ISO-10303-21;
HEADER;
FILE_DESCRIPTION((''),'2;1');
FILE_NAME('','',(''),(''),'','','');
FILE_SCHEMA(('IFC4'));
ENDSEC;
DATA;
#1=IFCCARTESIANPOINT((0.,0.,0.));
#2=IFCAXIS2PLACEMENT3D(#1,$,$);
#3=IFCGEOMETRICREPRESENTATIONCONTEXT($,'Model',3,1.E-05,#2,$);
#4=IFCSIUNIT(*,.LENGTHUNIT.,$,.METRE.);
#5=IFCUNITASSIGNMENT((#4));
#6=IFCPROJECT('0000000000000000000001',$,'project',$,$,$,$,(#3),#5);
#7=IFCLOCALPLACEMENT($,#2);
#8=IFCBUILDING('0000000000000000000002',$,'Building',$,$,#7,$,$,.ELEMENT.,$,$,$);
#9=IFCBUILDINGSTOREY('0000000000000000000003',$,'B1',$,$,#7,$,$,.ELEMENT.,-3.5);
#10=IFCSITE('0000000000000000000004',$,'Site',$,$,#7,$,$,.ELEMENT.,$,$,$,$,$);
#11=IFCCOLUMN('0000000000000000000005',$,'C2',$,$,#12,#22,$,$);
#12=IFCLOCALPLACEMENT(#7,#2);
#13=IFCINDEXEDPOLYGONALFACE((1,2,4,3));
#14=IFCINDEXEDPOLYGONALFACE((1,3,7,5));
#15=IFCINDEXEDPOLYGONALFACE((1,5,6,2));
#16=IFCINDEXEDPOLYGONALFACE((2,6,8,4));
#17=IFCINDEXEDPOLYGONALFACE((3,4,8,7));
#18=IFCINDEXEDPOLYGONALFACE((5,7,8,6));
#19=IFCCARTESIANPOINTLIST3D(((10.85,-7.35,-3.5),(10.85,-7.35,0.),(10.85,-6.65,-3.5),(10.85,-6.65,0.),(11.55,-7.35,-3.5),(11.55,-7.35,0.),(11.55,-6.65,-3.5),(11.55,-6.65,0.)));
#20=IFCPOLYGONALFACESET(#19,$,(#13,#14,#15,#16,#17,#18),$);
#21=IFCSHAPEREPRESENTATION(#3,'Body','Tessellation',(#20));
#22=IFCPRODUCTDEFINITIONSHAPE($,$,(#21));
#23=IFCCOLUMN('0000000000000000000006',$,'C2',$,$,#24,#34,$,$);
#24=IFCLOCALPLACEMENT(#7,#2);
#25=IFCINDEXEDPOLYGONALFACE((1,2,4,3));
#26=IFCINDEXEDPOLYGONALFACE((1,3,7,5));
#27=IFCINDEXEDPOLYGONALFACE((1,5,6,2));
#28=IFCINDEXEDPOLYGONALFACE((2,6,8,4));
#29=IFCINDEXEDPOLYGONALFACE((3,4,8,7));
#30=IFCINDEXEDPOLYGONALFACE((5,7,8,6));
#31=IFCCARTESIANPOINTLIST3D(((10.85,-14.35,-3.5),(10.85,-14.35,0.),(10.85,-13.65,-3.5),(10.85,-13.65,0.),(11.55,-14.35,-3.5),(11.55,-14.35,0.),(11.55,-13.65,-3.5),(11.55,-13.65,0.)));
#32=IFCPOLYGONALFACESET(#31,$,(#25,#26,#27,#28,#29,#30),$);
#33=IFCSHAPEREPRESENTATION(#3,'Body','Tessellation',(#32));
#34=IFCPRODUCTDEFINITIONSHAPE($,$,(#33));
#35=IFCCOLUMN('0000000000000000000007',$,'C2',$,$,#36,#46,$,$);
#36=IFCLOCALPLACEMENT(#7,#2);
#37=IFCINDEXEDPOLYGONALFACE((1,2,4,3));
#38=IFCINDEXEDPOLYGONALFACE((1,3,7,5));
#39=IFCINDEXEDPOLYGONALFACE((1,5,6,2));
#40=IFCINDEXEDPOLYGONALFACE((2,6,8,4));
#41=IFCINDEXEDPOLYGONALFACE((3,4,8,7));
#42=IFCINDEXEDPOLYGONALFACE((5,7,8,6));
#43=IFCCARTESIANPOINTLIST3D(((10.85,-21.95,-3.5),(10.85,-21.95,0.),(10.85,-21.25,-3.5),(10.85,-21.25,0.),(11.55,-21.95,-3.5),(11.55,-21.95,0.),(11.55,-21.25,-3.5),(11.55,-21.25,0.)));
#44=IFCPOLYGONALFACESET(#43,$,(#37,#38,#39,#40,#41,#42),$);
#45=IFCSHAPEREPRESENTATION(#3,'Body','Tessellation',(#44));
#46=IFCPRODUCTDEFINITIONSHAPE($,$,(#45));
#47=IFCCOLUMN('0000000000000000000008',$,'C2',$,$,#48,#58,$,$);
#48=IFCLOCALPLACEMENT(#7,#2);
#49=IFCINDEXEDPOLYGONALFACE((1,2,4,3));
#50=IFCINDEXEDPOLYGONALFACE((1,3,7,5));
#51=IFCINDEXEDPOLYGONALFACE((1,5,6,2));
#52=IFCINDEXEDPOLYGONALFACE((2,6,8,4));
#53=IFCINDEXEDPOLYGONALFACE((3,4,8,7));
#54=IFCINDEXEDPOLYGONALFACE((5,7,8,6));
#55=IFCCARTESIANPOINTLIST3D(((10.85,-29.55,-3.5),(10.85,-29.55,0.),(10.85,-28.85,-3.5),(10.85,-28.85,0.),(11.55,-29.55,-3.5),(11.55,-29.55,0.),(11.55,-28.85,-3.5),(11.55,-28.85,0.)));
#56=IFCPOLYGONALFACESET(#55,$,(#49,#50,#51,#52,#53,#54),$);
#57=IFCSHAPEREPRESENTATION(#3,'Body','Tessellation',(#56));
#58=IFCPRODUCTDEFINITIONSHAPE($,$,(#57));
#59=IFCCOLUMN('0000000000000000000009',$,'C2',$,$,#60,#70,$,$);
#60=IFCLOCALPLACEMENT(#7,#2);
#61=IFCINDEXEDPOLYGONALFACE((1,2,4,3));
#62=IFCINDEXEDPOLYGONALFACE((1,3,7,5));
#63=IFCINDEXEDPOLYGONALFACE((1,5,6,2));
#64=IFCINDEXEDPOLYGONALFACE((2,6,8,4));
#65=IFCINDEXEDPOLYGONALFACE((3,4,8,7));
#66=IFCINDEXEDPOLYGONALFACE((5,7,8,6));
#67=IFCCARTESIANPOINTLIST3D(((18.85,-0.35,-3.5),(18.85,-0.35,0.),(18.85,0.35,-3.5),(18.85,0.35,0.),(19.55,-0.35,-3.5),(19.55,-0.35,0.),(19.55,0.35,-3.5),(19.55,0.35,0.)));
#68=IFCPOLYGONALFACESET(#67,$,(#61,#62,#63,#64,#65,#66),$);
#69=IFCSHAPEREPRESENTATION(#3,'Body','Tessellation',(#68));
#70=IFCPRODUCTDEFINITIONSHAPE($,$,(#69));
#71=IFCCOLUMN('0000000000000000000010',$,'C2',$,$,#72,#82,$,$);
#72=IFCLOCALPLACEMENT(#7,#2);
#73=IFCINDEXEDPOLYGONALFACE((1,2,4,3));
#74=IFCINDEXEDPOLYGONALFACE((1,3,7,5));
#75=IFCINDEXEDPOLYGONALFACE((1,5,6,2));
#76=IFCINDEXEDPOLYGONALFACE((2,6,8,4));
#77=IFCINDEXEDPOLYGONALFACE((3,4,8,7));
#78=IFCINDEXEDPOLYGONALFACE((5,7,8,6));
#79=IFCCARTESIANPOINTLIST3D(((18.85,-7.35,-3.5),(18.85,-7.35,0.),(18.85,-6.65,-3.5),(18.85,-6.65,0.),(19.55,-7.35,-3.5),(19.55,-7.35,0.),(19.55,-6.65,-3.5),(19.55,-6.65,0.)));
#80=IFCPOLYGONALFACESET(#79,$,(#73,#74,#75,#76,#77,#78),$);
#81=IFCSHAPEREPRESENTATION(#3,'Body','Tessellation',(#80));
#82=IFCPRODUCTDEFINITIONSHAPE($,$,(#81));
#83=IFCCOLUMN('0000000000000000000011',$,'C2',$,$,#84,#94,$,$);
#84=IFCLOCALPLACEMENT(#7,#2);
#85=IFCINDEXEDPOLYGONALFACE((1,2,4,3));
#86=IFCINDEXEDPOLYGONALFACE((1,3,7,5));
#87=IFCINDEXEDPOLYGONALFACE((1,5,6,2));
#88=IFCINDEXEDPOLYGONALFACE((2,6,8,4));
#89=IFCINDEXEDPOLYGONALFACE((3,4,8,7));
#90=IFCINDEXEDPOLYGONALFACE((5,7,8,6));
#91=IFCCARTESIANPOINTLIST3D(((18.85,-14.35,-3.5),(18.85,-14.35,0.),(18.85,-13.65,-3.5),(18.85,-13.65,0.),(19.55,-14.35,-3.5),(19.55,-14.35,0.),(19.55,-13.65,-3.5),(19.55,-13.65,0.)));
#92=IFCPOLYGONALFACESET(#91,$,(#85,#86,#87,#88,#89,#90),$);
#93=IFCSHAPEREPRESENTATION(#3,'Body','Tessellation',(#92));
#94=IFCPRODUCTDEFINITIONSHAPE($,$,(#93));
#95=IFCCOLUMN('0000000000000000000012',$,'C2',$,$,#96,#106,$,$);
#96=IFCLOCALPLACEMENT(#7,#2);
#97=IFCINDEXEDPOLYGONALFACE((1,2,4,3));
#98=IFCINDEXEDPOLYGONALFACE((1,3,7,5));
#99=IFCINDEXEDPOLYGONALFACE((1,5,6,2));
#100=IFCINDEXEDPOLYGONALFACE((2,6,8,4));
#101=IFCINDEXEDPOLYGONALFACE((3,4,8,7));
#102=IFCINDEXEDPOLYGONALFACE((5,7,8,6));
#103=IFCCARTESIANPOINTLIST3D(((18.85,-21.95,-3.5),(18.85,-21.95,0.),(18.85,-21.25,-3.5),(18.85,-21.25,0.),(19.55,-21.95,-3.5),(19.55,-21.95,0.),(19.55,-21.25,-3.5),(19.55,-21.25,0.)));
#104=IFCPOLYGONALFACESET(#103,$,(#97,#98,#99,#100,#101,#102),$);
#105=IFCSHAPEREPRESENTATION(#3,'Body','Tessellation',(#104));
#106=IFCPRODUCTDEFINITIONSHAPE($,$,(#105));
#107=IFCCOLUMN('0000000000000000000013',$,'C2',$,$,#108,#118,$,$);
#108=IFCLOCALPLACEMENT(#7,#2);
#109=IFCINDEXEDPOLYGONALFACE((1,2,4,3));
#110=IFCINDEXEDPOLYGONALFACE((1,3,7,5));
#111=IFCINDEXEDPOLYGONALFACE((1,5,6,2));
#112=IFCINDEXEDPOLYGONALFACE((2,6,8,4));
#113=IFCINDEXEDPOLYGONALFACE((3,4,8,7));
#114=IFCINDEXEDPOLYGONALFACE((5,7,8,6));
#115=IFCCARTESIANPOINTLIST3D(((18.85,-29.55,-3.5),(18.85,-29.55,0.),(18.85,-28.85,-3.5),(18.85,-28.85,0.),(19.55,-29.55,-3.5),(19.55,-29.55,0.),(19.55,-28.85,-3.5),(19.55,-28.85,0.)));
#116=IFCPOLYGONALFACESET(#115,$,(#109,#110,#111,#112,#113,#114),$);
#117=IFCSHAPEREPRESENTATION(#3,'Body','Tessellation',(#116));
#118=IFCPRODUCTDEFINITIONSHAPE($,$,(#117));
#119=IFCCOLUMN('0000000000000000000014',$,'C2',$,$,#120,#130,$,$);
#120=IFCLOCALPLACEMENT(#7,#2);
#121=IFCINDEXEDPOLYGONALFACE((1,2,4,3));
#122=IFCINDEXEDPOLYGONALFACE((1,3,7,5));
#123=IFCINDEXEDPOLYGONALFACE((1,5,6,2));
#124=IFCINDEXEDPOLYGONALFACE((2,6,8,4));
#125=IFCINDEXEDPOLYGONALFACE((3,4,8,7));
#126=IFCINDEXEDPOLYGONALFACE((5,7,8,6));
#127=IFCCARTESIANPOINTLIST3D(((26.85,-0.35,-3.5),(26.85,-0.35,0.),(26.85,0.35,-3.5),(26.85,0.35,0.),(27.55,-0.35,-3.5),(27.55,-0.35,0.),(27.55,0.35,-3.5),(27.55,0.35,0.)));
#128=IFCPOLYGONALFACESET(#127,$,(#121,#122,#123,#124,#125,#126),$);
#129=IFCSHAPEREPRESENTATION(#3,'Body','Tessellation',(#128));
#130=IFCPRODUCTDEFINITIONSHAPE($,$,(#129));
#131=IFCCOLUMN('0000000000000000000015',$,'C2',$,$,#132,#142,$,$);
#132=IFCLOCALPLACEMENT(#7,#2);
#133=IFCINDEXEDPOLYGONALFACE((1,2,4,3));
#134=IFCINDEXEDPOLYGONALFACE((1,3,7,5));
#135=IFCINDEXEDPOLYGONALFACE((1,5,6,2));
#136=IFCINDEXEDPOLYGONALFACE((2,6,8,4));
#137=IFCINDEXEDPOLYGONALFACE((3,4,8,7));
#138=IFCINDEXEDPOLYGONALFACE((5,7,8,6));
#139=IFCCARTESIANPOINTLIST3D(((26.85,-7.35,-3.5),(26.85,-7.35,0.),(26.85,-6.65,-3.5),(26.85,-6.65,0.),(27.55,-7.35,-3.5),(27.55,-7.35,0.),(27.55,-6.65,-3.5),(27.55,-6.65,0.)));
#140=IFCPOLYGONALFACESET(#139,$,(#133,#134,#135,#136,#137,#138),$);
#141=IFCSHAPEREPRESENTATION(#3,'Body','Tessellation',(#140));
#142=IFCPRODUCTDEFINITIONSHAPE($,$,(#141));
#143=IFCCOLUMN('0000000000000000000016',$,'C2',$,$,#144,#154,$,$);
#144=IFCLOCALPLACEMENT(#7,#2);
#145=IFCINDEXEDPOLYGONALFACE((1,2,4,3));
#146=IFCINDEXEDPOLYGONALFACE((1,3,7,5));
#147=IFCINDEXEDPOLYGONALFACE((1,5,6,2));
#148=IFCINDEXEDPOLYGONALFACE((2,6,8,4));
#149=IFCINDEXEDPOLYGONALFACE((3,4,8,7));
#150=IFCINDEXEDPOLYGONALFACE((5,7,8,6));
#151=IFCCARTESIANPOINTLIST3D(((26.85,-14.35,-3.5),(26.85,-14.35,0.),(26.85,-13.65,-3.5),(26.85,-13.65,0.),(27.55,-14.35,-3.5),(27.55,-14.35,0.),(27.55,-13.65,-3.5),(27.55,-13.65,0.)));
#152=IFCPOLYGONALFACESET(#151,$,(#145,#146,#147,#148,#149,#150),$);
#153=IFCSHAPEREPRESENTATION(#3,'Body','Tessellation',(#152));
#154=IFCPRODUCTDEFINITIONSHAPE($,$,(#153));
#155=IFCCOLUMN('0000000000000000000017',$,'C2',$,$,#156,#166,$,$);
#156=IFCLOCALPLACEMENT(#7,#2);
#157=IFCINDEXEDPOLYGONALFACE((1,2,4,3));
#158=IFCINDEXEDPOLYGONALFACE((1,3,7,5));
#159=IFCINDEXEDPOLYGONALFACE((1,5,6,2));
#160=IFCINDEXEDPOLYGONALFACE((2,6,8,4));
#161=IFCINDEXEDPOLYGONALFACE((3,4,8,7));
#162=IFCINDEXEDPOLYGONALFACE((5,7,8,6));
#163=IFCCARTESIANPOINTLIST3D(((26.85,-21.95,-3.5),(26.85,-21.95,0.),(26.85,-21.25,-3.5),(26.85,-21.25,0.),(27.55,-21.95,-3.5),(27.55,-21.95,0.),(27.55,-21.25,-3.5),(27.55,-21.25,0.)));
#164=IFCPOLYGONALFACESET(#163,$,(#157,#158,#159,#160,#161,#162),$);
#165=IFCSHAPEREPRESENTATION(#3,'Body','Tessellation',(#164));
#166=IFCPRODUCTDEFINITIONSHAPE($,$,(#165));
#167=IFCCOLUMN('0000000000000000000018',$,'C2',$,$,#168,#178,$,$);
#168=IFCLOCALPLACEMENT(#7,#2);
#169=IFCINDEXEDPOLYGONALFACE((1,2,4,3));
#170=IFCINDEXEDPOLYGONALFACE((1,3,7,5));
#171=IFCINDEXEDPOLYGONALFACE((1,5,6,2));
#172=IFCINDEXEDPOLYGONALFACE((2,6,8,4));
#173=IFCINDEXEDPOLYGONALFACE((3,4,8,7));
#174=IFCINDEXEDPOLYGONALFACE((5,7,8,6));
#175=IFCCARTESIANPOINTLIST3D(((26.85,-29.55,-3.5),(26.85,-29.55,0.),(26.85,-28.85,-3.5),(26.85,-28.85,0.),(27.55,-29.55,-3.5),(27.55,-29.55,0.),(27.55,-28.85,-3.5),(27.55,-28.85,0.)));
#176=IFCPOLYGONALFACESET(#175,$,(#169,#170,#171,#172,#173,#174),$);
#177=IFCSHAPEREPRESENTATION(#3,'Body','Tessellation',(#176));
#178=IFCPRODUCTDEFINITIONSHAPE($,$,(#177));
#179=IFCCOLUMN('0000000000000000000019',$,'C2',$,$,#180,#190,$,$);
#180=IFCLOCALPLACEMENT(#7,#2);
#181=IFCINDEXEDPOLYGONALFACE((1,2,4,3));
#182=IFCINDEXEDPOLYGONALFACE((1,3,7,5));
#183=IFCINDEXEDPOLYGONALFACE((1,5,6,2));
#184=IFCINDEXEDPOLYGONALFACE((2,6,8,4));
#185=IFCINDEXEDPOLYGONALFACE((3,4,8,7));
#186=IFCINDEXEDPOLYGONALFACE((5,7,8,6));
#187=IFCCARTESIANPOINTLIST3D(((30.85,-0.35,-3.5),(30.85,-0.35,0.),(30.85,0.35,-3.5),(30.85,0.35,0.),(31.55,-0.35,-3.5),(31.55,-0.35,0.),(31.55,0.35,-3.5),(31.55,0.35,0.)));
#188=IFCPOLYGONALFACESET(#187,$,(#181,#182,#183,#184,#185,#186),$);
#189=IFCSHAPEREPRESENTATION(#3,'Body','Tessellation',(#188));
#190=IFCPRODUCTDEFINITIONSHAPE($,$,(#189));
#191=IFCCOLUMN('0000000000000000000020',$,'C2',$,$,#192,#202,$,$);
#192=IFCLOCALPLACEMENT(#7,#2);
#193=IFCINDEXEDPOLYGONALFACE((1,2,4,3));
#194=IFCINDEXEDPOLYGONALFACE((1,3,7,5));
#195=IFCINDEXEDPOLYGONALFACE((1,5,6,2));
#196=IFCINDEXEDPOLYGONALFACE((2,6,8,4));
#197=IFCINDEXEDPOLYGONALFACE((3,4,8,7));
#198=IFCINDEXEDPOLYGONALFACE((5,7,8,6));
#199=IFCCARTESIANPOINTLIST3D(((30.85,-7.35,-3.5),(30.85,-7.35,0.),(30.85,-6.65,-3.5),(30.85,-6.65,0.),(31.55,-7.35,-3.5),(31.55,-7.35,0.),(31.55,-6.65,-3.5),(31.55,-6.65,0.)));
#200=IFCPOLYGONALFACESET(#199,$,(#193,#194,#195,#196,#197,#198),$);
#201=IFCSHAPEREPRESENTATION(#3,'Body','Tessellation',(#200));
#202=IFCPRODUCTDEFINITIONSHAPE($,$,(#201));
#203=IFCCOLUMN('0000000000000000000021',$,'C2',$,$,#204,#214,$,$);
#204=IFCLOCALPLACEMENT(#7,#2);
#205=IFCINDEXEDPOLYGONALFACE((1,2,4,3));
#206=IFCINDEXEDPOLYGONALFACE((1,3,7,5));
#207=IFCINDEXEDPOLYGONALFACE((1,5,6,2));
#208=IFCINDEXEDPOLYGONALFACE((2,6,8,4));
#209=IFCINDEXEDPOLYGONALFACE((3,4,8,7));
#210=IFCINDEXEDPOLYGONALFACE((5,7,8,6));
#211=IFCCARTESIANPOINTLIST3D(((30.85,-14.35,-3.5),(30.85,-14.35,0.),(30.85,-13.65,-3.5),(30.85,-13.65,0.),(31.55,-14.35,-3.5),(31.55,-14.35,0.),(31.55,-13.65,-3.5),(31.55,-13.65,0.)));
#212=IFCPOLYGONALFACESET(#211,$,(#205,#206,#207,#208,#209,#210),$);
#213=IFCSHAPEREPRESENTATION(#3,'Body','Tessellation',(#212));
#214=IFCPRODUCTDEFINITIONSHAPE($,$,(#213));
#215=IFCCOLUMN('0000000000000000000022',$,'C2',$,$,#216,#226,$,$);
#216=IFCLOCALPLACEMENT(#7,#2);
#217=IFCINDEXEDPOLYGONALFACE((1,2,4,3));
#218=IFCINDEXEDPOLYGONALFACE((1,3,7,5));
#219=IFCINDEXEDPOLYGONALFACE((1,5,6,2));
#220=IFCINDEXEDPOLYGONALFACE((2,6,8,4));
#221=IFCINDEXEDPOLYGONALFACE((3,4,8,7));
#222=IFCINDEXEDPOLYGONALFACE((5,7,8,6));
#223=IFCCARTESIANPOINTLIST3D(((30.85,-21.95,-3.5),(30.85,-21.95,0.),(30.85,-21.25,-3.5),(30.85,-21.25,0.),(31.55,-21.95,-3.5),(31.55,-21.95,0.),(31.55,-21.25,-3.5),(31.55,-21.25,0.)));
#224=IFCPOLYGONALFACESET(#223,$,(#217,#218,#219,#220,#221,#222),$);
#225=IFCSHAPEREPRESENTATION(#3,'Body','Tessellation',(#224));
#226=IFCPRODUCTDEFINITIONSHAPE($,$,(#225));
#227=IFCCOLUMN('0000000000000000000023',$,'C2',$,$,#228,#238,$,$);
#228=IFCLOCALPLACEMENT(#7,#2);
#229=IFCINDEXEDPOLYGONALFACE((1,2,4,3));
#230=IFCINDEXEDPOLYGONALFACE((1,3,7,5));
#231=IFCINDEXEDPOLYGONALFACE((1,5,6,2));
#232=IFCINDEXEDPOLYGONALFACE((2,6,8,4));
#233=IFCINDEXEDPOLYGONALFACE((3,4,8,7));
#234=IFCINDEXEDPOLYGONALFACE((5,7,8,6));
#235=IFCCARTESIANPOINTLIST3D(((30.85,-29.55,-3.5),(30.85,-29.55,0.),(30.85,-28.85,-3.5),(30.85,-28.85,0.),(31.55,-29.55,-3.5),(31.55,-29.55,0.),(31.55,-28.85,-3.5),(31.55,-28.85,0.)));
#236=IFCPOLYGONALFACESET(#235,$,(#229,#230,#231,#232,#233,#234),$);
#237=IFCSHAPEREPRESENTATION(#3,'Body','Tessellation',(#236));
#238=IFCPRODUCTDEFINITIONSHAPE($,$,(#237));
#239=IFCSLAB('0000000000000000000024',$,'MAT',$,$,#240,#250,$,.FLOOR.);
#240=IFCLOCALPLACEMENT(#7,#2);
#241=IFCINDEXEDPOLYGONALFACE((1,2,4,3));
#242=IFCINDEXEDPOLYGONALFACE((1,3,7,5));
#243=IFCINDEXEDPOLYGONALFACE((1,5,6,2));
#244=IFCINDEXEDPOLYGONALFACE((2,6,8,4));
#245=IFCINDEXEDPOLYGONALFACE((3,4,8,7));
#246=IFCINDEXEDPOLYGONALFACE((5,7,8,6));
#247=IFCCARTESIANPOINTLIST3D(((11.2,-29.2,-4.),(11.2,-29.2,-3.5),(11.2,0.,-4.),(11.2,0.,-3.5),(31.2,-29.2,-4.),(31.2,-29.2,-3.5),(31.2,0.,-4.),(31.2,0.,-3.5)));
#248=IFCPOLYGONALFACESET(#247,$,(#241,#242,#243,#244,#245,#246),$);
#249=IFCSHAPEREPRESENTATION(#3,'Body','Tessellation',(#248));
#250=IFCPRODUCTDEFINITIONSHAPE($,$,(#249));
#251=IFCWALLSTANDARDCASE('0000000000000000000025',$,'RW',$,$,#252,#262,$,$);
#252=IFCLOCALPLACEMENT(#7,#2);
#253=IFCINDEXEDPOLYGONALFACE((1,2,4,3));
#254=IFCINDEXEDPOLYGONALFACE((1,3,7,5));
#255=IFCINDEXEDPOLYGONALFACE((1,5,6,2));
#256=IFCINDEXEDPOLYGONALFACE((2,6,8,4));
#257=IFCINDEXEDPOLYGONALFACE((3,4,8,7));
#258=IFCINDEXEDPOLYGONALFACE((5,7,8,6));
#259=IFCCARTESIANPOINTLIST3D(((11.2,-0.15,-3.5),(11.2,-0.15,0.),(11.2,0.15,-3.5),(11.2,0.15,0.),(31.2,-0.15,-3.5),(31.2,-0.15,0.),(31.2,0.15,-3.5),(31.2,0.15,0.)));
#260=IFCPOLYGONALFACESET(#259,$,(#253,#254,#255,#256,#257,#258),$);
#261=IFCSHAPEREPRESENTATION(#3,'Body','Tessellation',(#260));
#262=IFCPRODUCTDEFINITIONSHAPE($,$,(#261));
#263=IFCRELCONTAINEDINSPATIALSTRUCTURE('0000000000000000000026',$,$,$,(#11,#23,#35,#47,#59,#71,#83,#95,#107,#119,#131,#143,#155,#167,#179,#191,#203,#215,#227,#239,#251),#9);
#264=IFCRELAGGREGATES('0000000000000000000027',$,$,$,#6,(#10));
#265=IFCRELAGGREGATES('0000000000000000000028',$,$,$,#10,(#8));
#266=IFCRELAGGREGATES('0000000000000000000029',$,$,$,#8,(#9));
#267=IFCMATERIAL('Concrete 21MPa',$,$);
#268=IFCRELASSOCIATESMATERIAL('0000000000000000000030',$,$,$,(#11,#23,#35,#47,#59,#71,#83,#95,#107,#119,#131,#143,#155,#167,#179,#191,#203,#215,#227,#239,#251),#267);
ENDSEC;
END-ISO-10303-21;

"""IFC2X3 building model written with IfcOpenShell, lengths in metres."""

from ifc_helpers import new_model, si_unit, frame, origin, origin_2d, place, context, project, spatial, rectangle, extrude, material, element, save


model = new_model("IFC2X3")

# Units and contexts
model_context = context("Model", 3, precision=1e-05, world=origin())
ifc_project = project(units=[si_unit("LENGTHUNIT", "METRE")], contexts=[model_context])

# Site, building, storey
placement = place(None, origin())
site = spatial("IfcSite", under=ifc_project, at=placement, Name="Site", CompositionType="ELEMENT")
building = spatial("IfcBuilding", under=site, at=placement, Name="Building", CompositionType="ELEMENT")
storey = spatial("IfcBuildingStorey", under=building, at=placement, Name="B1", CompositionType="ELEMENT", Elevation=-3.5)

# Columns
ifc_material_1 = material(Name="Concrete 21MPa")
for number, where, name in (
    (1, (11.2, -7.0, -3.5), "C2"),
    (2, (11.2, -14.0, -3.5), "C2"),
    (3, (11.2, -21.6, -3.5), "C2"),
    (4, (11.2, -29.2, -3.5), "C2"),
    (5, (19.2, 0.0, -3.5), "C2"),
    (6, (19.2, -7.0, -3.5), "C2"),
    (7, (19.2, -14.0, -3.5), "C2"),
    (8, (19.2, -21.6, -3.5), "C2"),
    (9, (19.2, -29.2, -3.5), "C2"),
    (10, (27.2, 0.0, -3.5), "C2"),
    (11, (27.2, -7.0, -3.5), "C2"),
    (12, (27.2, -14.0, -3.5), "C2"),
    (13, (27.2, -21.6, -3.5), "C2"),
    (14, (27.2, -29.2, -3.5), "C2"),
    (15, (31.2, 0.0, -3.5), "C2"),
    (16, (31.2, -7.0, -3.5), "C2"),
    (17, (31.2, -14.0, -3.5), "C2"),
    (18, (31.2, -21.6, -3.5), "C2"),
    (19, (31.2, -29.2, -3.5), "C2"),
):
    element("IfcColumn", number, at=place(None, frame(where)), inside=storey, material=ifc_material_1, Name=name, context=model_context, shape_type="SweptSolid", body=[
        extrude(rectangle(XDim=0.7, YDim=0.7, at=origin_2d()), origin(), (0.0, 0.0, 1.0), 3.5),
    ])

# Slab
slab_placement = place(None, frame((21.2, -14.6, -4.0)))
element("IfcSlab", 20, at=slab_placement, inside=storey, material=ifc_material_1, Name="MAT", PredefinedType="FLOOR", context=model_context, shape_type="SweptSolid", body=[
    extrude(rectangle(XDim=20.0, YDim=29.2, at=origin_2d()), origin(), (0.0, 0.0, 1.0), 0.5),
])

# Wall
for number, where, name in (
    (21, (21.2, 0.0, -3.5), "RW"),
):
    element("IfcWallStandardCase", number, at=place(None, frame(where)), inside=storey, material=ifc_material_1, Name=name, context=model_context, shape_type="SweptSolid", body=[
        extrude(rectangle(XDim=20.0, YDim=0.3, at=origin_2d()), origin(), (0.0, 0.0, 1.0), 3.5),
    ])

save(model, "model.ifc")
